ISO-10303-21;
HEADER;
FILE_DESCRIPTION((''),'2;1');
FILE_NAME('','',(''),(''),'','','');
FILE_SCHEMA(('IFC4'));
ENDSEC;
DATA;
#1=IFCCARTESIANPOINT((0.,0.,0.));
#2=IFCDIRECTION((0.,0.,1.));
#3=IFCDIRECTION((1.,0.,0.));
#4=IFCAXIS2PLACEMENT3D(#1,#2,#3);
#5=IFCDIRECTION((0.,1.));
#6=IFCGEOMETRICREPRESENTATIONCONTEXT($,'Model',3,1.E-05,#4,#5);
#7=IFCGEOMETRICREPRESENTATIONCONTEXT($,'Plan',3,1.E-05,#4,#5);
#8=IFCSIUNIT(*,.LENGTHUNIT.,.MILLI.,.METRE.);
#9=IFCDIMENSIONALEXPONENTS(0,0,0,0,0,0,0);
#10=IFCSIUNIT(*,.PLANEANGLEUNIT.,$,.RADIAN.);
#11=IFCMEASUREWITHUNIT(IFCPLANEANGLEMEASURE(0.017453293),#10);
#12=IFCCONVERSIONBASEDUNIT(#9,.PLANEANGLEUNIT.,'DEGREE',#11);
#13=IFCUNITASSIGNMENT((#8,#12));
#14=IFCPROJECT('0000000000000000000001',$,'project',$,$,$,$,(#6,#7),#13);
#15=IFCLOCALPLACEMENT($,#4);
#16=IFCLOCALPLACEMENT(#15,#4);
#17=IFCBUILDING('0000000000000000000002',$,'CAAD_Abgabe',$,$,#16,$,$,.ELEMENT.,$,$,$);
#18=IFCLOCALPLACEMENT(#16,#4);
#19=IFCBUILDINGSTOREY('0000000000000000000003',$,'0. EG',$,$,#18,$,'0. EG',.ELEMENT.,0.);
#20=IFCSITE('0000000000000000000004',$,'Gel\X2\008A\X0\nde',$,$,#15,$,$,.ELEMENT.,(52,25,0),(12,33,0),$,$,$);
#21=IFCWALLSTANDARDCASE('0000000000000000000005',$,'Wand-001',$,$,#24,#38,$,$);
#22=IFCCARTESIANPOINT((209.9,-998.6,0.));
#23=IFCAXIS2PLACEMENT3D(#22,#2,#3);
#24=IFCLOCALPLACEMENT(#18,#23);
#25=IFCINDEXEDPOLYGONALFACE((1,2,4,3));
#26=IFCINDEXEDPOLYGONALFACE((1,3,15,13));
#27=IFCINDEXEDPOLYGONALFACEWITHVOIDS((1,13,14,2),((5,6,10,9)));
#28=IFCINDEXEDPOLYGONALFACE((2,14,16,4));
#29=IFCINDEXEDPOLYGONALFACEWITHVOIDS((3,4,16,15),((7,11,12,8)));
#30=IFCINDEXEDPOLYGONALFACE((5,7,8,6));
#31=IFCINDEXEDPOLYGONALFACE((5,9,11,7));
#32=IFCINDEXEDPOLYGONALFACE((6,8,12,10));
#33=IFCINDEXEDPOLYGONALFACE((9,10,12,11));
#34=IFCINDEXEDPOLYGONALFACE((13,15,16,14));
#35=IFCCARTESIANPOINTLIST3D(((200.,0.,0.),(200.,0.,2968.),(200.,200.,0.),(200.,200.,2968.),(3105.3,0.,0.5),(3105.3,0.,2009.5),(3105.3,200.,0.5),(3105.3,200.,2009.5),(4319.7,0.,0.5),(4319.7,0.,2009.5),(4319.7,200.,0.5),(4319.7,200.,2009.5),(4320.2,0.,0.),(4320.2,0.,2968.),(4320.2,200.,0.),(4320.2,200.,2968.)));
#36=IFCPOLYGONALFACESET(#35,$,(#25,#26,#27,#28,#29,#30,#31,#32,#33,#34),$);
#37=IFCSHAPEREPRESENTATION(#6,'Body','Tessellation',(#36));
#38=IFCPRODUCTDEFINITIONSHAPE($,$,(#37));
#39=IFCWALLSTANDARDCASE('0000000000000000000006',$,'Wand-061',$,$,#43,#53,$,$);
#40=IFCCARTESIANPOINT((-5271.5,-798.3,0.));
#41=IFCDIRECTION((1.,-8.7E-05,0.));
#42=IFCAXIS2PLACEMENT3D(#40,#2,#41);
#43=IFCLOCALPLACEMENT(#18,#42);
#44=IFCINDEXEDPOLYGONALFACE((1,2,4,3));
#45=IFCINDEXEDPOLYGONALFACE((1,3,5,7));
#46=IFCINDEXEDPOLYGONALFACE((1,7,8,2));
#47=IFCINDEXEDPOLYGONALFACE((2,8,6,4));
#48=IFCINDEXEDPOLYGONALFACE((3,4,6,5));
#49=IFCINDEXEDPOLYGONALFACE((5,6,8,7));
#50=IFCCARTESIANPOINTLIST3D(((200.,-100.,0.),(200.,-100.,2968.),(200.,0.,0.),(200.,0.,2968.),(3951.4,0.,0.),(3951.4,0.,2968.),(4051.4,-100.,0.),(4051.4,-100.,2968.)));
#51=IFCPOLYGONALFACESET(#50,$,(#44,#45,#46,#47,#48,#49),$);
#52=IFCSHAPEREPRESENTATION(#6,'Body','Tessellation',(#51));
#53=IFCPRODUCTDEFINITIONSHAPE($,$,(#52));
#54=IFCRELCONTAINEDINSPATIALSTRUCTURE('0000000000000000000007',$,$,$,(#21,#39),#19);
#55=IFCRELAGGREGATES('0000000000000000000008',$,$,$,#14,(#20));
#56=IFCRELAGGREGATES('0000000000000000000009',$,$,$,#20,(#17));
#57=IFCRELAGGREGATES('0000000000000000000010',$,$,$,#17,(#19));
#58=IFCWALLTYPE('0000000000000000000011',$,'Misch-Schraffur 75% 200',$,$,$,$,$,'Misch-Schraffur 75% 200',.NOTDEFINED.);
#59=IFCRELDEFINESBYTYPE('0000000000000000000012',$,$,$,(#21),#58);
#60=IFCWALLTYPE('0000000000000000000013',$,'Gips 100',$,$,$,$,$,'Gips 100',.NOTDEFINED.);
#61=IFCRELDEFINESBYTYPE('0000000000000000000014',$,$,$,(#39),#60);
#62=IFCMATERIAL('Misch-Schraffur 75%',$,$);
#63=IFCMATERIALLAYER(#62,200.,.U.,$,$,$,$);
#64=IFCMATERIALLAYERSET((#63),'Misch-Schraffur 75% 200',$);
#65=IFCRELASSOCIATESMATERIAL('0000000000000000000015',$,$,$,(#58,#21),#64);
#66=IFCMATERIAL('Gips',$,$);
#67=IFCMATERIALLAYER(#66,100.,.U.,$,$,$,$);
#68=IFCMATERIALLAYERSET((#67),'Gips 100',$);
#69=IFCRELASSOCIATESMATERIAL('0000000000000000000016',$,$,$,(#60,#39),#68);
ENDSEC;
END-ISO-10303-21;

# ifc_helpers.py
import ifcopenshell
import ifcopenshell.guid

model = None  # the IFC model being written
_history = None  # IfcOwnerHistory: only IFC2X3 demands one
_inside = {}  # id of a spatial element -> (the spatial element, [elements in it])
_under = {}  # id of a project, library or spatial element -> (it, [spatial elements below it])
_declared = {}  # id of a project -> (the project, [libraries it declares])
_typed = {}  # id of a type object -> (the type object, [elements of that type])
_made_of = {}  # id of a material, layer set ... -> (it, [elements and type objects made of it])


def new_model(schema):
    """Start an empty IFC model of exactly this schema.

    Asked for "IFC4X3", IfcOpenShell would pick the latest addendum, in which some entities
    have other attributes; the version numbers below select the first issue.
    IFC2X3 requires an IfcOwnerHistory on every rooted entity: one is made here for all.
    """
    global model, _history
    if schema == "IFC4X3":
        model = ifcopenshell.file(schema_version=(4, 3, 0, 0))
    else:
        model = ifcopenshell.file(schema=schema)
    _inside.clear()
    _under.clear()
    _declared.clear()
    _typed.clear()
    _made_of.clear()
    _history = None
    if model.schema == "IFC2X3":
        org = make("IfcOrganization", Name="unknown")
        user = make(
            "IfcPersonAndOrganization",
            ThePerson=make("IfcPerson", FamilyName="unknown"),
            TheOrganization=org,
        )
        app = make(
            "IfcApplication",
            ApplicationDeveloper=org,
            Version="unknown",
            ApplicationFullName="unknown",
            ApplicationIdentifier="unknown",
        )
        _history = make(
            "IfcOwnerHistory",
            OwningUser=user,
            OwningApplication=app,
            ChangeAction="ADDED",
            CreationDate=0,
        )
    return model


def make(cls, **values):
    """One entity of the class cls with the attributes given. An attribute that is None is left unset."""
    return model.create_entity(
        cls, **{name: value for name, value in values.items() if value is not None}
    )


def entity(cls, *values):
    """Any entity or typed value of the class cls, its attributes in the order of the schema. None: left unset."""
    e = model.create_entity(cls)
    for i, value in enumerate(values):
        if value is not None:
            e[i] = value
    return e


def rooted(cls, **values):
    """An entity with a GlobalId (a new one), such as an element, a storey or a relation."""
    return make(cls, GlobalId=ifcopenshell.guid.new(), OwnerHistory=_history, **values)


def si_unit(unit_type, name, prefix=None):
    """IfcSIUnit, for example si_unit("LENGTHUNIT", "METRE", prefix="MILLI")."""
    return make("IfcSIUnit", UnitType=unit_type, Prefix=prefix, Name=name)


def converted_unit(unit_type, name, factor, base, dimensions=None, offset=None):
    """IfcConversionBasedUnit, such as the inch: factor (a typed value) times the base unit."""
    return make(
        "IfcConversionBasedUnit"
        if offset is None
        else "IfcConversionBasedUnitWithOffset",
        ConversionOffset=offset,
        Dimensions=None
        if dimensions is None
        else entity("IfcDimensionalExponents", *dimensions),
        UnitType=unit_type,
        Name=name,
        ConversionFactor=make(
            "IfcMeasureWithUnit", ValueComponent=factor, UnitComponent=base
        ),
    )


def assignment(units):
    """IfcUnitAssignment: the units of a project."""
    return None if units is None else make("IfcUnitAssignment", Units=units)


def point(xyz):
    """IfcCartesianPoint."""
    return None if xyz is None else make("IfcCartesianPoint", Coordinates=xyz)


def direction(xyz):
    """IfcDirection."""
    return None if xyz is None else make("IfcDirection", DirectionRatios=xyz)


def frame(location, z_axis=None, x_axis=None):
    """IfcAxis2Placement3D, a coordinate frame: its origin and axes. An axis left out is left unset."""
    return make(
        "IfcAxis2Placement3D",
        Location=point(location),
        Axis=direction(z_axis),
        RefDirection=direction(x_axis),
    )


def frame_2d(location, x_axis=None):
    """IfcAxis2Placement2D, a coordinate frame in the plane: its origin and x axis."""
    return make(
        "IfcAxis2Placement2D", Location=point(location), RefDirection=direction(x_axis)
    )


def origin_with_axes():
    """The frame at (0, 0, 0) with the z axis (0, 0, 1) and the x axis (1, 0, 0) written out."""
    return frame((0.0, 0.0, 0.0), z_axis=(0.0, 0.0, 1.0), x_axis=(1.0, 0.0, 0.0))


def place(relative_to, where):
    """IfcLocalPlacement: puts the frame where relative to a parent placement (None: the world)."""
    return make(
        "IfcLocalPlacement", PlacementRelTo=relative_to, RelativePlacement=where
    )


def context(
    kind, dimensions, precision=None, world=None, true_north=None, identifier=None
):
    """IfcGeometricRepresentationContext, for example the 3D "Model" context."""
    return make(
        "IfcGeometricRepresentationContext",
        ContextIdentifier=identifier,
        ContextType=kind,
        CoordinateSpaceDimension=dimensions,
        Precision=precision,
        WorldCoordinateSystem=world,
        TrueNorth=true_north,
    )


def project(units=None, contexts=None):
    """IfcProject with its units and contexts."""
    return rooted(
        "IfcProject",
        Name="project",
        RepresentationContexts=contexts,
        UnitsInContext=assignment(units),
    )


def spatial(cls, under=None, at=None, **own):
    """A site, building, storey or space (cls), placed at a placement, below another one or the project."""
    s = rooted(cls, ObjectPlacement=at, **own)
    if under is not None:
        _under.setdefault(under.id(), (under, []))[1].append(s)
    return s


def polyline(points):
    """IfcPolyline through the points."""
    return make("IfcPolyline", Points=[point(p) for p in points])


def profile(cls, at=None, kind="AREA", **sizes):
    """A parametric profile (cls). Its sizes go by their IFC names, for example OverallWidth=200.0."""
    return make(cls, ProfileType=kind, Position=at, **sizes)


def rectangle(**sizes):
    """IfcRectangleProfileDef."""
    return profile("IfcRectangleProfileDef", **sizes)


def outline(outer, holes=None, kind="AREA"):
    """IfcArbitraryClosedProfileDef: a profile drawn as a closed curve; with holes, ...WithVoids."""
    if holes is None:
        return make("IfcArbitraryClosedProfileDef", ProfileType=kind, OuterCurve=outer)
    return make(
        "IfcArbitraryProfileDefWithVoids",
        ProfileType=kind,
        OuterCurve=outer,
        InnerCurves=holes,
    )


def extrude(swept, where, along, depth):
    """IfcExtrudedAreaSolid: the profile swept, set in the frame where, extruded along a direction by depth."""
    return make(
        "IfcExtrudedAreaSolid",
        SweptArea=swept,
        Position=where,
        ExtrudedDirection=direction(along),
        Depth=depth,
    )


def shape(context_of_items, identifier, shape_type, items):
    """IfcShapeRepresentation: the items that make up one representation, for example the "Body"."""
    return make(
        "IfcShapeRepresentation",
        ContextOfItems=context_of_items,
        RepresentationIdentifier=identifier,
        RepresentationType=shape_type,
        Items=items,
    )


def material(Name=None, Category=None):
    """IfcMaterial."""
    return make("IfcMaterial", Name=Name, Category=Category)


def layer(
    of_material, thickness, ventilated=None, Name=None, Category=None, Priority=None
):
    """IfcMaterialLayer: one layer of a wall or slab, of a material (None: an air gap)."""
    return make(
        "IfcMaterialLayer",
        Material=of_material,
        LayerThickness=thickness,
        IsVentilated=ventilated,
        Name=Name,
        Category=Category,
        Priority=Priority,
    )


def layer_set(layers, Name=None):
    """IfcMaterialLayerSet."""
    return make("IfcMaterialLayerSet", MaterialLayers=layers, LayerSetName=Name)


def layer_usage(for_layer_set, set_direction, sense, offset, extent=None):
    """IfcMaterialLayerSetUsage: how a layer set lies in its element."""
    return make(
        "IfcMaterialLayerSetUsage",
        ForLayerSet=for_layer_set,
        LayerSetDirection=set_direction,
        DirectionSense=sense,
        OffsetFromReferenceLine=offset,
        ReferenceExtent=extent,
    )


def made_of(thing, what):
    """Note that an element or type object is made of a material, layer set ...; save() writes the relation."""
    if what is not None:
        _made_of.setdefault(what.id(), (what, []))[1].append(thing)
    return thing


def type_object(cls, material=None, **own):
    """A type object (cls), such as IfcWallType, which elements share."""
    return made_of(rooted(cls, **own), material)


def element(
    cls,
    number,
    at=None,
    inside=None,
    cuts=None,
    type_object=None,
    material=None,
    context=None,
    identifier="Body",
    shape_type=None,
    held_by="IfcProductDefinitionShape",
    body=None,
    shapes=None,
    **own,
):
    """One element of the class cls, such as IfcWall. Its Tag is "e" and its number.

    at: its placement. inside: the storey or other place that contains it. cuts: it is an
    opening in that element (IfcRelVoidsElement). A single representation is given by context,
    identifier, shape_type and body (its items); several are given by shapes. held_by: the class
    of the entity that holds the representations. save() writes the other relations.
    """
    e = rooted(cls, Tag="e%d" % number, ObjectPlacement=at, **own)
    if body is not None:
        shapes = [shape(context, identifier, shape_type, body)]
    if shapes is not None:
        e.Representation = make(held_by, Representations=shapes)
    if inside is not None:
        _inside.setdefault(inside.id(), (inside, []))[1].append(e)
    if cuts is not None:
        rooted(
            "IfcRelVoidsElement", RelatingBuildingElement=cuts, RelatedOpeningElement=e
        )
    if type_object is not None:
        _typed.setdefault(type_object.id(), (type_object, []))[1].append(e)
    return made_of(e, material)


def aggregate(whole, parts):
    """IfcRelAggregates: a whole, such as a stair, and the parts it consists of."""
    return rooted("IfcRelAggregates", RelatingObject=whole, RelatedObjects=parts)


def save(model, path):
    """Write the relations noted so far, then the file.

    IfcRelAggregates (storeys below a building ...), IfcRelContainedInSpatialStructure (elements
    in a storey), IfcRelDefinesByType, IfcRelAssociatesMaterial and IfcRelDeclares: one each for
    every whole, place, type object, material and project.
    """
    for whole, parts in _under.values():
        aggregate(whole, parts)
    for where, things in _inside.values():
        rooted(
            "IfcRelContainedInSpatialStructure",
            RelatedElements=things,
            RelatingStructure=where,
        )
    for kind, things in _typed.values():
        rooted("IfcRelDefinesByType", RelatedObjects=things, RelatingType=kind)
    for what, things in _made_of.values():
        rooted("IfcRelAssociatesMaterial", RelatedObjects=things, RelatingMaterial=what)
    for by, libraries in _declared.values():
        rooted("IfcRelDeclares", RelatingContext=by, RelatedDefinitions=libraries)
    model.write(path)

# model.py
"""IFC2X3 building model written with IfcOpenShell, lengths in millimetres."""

from ifc_helpers import new_model, entity, si_unit, converted_unit, direction, frame, frame_2d, origin_with_axes, place, context, project, spatial, polyline, rectangle, outline, extrude, material, layer, layer_set, layer_usage, type_object, element, save


model = new_model("IFC2X3")

# Units and contexts
model_context = context("Model", 3, precision=1e-05, world=origin_with_axes(), true_north=direction((0.0, 1.0)))
plan_context = context("Plan", 3, precision=1e-05, world=origin_with_axes(), true_north=direction((0.0, 1.0)))
ifc_project = project(units=[si_unit("LENGTHUNIT", "METRE", prefix="MILLI"), converted_unit("PLANEANGLEUNIT", "DEGREE", entity("IfcPlaneAngleMeasure", 0.017453293), si_unit("PLANEANGLEUNIT", "RADIAN"), dimensions=[0, 0, 0, 0, 0, 0, 0])], contexts=[model_context, plan_context])

# Site, building, storey
site_placement = place(None, origin_with_axes())
site = spatial("IfcSite", under=ifc_project, at=site_placement, Name="Gel\u008ande", CompositionType="ELEMENT", RefLatitude=(52, 25, 0), RefLongitude=(12, 33, 0))
building_placement = place(site_placement, origin_with_axes())
building = spatial("IfcBuilding", under=site, at=building_placement, Name="CAAD_Abgabe", CompositionType="ELEMENT")
storey_placement = place(building_placement, origin_with_axes())
storey = spatial("IfcBuildingStorey", under=building, at=storey_placement, Name="0. EG", LongName="0. EG", CompositionType="ELEMENT", Elevation=0.0)

# Shared definitions
ifc_material_1 = material(Name="Misch-Schraffur 75%")

# Shared definitions
ifc_layer_1 = layer(ifc_material_1, 200.0, ventilated="UNKNOWN")
ifc_layer_set_1 = layer_set([ifc_layer_1], Name="Misch-Schraffur 75% 200")
wall_type_1 = type_object("IfcWallType", Name="Misch-Schraffur 75% 200", ElementType="Misch-Schraffur 75% 200", PredefinedType="NOTDEFINED", material=ifc_layer_set_1)

# Wall, opening
ifc_layer_usage_1 = layer_usage(ifc_layer_set_1, "AXIS2", "POSITIVE", 0.0)
wall_1_placement = place(storey_placement, frame((209.9, -998.6, 0.0), z_axis=(0.0, 0.0, 1.0), x_axis=(1.0, 0.0, 0.0)))
wall_1 = element("IfcWallStandardCase", 1, at=wall_1_placement, inside=storey, type_object=wall_type_1, material=ifc_layer_usage_1, Name="Wand-001", context=model_context, shape_type="SweptSolid", body=[
    extrude(outline(polyline([(200.0, 0.0), (4320.2, 0.0), (4320.2, 200.0), (200.0, 200.0), (200.0, 0.0)])), origin_with_axes(), (0.0, 0.0, 1.0), 2968.0),
])
opening_1_placement = place(wall_1_placement, frame((3712.5, 0.0, 0.0), z_axis=(0.0, 0.0, 1.0), x_axis=(1.0, 0.0, 0.0)))
element("IfcOpeningElement", 2, at=opening_1_placement, cuts=wall_1, ObjectType="Opening", context=model_context, shape_type="SweptSolid", body=[
    extrude(rectangle(XDim=1214.4, YDim=2009.0, at=frame_2d((0.0, 1005.0), x_axis=(1.0, 0.0))), frame((0.0, 0.0, 0.0), z_axis=(0.0, 1.0, 0.0), x_axis=(-1.0, 0.0, 0.0)), (0.0, 0.0, 1.0), 200.0),
])

# Wall
ifc_material_2 = material(Name="Gips")
ifc_layer_2 = layer(ifc_material_2, 100.0, ventilated="UNKNOWN")
ifc_layer_set_2 = layer_set([ifc_layer_2], Name="Gips 100")
ifc_layer_usage_2 = layer_usage(ifc_layer_set_2, "AXIS2", "NEGATIVE", 0.0)
wall_type_2 = type_object("IfcWallType", Name="Gips 100", ElementType="Gips 100", PredefinedType="NOTDEFINED", material=ifc_layer_set_2)
wall_2_placement = place(storey_placement, frame((-5271.5, -798.3, 0.0), z_axis=(0.0, 0.0, 1.0), x_axis=(1.0, -0.000087, 0.0)))
element("IfcWallStandardCase", 3, at=wall_2_placement, inside=storey, type_object=wall_type_2, material=ifc_layer_usage_2, Name="Wand-061", context=model_context, shape_type="SweptSolid", body=[
    extrude(outline(polyline([(200.0, -100.0), (4051.4, -100.0), (3951.4, 0.0), (200.0, 0.0), (200.0, -100.0)])), origin_with_axes(), (0.0, 0.0, 1.0), 2968.0),
])

save(model, "model.ifc")
